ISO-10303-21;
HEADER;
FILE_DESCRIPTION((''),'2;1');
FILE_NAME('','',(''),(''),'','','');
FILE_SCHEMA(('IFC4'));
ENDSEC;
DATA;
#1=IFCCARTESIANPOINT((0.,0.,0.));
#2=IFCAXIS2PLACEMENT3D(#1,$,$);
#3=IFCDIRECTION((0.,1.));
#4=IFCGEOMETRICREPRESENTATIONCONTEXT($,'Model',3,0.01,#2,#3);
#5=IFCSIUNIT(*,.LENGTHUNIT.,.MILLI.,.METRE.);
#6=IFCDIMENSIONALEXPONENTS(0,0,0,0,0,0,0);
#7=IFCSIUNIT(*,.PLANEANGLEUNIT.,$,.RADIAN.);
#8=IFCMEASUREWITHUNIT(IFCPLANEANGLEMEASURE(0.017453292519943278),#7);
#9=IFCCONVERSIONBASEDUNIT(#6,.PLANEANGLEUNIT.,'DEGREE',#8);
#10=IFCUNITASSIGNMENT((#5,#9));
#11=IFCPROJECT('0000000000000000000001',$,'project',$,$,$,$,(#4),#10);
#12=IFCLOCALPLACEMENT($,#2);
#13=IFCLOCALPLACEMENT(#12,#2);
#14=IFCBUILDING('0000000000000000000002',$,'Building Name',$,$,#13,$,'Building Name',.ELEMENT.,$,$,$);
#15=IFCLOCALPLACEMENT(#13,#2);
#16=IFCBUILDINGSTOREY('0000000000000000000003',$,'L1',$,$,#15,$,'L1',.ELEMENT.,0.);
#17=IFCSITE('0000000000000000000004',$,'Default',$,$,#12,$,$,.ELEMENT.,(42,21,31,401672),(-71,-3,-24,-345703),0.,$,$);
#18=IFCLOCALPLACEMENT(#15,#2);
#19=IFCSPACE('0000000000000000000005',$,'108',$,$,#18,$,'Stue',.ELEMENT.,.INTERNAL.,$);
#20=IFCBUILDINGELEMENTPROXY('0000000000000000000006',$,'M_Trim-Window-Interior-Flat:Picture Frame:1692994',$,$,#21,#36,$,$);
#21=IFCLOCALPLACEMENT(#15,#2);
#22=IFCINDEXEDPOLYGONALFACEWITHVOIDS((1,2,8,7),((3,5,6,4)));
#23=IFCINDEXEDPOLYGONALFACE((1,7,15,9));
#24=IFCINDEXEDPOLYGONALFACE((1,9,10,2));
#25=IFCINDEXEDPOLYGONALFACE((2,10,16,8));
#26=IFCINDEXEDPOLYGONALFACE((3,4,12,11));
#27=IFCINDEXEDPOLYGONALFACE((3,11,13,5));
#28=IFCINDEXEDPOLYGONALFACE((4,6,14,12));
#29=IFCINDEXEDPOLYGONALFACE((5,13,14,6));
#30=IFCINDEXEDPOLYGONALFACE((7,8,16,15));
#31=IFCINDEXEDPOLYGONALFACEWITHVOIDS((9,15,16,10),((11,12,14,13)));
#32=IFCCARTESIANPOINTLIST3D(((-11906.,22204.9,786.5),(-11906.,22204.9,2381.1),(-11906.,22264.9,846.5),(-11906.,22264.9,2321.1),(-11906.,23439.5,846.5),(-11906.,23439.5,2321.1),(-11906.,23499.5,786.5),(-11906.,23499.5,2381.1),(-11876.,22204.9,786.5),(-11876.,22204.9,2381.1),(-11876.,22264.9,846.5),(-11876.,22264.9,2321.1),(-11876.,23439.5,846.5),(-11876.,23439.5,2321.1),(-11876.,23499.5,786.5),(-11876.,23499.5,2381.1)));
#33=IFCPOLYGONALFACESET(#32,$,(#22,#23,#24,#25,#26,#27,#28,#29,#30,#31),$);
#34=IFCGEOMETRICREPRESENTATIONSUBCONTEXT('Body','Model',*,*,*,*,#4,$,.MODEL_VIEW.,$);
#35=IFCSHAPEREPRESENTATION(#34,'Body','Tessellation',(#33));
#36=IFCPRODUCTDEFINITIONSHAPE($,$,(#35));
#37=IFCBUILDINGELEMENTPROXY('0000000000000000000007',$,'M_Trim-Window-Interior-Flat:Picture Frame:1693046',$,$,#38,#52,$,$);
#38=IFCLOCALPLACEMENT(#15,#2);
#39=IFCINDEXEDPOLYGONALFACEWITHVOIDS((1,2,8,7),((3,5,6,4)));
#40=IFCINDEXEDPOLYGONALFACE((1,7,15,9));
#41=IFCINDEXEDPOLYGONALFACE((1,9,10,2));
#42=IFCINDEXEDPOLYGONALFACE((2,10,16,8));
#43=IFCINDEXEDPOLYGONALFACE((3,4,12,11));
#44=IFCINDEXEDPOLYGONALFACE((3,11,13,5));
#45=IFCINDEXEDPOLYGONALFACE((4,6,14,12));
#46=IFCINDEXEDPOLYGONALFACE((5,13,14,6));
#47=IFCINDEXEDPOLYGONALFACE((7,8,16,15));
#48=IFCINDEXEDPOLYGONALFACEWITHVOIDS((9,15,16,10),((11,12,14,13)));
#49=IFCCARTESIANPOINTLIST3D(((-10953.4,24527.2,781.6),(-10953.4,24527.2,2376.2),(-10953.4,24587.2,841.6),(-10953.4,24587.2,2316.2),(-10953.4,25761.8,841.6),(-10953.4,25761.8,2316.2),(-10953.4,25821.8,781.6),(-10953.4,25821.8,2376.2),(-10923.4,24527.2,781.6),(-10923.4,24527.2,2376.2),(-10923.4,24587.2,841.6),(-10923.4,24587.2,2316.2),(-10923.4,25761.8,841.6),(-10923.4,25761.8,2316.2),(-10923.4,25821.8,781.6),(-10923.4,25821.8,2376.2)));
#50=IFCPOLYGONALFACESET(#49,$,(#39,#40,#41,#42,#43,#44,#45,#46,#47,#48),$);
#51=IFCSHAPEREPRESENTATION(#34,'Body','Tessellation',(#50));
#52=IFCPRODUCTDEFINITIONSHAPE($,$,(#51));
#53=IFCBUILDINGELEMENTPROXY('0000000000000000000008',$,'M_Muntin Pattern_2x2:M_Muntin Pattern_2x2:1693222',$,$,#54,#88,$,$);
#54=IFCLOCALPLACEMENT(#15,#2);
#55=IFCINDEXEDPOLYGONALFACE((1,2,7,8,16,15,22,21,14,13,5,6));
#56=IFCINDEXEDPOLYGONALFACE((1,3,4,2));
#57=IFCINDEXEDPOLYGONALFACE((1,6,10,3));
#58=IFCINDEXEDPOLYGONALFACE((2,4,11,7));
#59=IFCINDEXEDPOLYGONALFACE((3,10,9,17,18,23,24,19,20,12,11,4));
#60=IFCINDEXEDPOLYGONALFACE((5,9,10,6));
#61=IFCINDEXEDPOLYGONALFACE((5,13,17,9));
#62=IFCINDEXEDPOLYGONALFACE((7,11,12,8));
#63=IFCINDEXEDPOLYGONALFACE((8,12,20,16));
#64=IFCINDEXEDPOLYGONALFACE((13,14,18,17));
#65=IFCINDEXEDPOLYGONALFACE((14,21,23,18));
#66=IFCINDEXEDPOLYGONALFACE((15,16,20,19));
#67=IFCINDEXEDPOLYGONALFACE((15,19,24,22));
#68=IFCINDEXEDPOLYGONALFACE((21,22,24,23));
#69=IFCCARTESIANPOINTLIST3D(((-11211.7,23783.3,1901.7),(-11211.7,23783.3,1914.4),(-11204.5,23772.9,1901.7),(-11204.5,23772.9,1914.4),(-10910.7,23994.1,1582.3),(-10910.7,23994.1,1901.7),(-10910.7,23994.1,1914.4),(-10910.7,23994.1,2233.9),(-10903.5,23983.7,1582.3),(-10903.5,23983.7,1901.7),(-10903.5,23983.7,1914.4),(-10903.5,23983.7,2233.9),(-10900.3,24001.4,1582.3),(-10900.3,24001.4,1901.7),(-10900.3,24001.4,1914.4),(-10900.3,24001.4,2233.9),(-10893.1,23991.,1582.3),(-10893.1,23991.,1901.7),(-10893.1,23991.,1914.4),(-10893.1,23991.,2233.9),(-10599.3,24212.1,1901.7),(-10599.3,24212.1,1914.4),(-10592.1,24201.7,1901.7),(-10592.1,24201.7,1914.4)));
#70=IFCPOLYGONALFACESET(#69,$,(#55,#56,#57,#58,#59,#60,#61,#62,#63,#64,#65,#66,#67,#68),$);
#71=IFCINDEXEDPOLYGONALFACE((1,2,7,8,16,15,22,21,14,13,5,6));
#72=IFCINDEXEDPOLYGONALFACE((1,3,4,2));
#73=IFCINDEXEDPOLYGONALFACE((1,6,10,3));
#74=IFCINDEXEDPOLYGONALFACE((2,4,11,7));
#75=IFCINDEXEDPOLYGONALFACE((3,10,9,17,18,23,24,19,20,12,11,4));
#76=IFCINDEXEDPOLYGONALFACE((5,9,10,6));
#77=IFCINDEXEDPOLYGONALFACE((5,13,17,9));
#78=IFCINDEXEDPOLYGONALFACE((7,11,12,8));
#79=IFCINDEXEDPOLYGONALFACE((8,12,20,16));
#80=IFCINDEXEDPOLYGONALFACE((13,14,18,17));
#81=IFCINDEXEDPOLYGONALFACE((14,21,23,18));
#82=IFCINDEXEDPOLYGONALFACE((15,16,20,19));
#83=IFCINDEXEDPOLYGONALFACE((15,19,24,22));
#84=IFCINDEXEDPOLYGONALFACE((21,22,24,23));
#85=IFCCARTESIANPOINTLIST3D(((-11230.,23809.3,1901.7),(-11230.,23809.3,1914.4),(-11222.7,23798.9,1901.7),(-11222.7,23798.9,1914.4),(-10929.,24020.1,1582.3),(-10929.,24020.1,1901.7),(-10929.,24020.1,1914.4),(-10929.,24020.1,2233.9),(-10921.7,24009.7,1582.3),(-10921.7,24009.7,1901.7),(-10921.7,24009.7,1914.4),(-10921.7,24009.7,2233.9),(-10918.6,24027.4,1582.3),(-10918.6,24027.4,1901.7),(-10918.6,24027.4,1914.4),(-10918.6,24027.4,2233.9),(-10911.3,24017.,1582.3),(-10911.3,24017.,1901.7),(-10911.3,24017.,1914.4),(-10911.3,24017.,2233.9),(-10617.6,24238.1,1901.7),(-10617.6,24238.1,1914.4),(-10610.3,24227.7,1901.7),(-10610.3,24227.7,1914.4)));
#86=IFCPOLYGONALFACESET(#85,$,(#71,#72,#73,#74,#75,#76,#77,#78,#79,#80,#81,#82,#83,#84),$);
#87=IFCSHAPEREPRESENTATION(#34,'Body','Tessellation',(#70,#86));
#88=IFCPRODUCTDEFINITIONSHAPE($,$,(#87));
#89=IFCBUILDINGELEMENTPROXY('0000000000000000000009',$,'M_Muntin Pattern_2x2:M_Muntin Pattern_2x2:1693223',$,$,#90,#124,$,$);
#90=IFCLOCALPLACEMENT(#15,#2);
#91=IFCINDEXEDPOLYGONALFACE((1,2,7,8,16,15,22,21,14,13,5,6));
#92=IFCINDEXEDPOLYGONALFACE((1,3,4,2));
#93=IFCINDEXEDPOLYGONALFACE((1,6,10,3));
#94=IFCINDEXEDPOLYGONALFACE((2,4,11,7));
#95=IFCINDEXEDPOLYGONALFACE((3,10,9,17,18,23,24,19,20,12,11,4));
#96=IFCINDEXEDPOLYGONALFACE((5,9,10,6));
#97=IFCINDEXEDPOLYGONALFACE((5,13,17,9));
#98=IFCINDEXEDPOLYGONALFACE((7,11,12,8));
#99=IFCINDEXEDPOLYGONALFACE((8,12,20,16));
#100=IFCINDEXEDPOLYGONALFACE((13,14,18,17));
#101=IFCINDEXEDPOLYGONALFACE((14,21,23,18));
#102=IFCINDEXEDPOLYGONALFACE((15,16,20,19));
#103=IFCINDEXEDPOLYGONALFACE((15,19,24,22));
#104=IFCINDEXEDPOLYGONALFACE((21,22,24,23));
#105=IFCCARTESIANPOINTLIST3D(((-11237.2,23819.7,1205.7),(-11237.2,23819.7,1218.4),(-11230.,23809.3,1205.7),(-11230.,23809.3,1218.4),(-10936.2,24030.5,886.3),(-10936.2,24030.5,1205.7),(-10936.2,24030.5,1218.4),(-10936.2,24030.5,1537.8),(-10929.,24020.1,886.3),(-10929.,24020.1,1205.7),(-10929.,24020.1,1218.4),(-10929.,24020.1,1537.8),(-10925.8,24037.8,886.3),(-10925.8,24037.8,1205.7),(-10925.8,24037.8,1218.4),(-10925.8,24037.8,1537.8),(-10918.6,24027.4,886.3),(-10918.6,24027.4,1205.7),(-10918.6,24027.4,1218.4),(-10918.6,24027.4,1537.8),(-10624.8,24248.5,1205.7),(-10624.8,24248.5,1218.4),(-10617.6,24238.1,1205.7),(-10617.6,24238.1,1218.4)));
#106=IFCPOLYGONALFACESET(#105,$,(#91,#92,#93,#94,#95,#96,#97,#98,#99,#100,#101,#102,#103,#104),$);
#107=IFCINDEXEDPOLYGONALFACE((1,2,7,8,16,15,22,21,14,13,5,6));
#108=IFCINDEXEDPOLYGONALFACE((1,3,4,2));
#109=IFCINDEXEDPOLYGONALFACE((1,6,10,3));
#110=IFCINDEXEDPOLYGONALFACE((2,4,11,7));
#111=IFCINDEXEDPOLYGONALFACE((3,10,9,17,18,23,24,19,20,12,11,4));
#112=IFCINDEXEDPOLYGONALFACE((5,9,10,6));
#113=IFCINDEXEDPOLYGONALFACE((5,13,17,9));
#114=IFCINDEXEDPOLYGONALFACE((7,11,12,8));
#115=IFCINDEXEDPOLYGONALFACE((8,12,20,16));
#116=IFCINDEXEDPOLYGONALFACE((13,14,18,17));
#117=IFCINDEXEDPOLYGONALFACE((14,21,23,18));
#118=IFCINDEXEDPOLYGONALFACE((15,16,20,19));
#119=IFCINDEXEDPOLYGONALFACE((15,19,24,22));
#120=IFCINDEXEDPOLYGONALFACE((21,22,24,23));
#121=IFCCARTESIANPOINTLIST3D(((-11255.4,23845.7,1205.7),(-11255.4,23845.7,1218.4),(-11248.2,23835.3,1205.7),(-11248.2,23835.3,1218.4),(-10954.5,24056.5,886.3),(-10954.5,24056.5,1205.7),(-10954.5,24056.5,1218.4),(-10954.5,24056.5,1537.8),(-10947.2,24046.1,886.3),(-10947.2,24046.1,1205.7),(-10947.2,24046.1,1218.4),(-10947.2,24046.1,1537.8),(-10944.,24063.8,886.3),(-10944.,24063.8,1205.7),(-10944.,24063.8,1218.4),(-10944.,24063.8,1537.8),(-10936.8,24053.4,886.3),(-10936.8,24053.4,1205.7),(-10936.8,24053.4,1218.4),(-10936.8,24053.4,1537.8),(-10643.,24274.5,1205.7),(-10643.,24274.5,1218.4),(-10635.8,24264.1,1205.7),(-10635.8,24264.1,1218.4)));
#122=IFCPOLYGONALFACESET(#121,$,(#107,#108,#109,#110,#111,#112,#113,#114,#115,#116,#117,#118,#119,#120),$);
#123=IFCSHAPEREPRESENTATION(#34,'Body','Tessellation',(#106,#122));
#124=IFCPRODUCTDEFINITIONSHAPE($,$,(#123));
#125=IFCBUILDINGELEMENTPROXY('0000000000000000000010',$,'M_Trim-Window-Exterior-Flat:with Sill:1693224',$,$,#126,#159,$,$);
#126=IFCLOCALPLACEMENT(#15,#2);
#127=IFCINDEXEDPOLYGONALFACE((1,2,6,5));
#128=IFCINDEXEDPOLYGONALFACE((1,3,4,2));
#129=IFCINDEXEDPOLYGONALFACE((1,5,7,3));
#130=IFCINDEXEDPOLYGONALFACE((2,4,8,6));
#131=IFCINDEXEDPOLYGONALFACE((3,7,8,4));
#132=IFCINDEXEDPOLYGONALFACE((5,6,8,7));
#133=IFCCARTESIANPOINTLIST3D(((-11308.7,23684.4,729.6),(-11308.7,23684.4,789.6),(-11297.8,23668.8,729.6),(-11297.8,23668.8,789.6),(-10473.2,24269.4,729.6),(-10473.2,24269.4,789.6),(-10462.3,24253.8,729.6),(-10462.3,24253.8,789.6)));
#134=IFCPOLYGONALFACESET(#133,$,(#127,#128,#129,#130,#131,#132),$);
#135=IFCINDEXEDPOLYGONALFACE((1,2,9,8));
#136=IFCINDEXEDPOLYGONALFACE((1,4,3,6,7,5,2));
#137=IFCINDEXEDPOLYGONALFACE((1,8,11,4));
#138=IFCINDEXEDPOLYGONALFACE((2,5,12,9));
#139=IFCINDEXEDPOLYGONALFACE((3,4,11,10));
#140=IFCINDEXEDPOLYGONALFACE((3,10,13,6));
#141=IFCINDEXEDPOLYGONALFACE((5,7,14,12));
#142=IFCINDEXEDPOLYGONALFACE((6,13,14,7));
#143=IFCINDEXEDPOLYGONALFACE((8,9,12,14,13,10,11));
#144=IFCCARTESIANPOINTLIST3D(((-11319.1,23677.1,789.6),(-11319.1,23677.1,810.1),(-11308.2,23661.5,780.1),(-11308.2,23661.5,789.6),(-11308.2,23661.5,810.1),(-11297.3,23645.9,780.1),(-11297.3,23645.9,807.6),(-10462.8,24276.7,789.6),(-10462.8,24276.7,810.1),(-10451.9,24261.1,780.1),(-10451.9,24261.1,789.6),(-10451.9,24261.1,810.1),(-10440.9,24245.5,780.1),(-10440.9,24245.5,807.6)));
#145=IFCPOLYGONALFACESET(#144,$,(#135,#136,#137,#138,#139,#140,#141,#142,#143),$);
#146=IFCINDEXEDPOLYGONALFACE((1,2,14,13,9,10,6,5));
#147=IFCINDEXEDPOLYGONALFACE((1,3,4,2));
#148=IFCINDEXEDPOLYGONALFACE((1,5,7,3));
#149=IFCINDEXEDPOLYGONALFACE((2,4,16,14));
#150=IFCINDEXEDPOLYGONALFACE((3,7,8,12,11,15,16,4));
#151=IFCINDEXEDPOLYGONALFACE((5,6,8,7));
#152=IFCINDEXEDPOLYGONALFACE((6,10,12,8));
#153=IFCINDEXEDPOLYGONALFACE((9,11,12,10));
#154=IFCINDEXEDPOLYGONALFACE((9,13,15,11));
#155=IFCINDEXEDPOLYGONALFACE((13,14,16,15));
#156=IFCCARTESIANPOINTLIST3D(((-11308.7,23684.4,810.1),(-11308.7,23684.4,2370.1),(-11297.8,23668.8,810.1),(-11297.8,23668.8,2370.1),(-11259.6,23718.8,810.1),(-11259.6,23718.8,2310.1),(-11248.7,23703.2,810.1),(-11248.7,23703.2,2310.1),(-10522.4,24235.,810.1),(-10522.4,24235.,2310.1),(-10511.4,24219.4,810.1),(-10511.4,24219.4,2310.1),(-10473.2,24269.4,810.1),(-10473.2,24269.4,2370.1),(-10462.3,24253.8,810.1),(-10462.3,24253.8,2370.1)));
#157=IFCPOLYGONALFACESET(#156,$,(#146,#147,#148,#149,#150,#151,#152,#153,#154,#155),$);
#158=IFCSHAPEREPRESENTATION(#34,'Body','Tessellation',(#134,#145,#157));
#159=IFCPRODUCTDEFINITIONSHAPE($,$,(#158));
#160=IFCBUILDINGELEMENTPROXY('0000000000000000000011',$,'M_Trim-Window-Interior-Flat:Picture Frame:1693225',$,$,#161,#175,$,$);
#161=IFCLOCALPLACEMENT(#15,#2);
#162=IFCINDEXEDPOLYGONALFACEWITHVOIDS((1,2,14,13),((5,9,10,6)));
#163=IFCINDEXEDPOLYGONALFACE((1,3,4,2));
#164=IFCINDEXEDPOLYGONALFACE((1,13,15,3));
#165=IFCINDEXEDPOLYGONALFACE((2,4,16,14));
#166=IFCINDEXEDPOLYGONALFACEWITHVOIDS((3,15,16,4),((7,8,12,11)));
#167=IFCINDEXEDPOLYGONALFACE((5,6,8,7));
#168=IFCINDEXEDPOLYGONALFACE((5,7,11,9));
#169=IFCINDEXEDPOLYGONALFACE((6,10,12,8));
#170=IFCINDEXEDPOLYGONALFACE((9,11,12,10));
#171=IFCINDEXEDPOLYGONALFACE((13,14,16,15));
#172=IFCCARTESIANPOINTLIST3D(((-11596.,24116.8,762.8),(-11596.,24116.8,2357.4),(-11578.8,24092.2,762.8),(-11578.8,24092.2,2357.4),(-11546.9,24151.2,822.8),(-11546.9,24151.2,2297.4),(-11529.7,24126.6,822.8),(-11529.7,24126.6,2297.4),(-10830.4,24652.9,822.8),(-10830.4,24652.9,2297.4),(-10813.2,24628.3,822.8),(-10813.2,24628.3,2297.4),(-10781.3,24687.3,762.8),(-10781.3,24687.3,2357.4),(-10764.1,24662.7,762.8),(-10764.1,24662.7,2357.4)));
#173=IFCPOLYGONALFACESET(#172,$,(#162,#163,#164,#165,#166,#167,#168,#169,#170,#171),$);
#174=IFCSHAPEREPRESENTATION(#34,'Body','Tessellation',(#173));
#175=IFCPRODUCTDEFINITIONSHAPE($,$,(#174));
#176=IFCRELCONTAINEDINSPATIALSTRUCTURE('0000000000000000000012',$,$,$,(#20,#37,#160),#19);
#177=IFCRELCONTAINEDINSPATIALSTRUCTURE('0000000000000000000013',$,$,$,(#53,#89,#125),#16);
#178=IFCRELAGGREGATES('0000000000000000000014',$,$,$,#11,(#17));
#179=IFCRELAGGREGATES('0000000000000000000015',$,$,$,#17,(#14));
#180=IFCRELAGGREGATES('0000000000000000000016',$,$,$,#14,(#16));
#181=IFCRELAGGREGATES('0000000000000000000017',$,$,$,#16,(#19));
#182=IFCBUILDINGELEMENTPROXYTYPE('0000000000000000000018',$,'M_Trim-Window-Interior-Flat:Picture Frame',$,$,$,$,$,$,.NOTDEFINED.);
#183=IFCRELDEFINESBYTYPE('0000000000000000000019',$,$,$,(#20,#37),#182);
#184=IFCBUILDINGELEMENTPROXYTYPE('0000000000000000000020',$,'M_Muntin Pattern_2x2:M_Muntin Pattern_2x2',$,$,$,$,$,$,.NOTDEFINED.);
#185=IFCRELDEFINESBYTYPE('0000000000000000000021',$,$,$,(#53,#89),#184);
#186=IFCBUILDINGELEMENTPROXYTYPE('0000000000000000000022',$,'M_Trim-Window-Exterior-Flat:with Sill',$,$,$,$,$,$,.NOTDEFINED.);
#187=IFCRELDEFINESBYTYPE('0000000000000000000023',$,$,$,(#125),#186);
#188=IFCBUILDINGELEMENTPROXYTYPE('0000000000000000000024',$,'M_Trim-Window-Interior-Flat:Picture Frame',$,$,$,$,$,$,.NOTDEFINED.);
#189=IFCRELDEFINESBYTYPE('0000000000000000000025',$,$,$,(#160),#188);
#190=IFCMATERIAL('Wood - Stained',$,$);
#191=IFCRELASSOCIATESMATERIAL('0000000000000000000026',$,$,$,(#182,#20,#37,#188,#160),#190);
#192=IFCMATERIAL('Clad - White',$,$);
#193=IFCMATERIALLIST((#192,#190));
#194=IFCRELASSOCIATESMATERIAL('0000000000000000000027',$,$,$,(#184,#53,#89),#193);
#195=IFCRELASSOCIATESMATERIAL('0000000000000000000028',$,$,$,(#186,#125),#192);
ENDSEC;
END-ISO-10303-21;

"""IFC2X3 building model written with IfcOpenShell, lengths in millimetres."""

from ifc_helpers import new_model, entity, si_unit, converted_unit, direction, frame, frame_2d, origin, place, context, subcontext, project, spatial, polyline, rectangle, outline, extrude, source, transform, mapped, material, material_list, type_object, type_shapes, element, save


model = new_model("IFC2X3")

# Units and contexts
model_context = context("Model", 3, precision=0.01, world=origin(), true_north=direction((0.0, 1.0)))
body_context = subcontext(model_context, "Body", "Model", "MODEL_VIEW")
ifc_project = project(units=[si_unit("LENGTHUNIT", "METRE", prefix="MILLI"), converted_unit("PLANEANGLEUNIT", "DEGREE", entity("IfcPlaneAngleMeasure", 0.017453292519943278), si_unit("PLANEANGLEUNIT", "RADIAN"), dimensions=[0, 0, 0, 0, 0, 0, 0])], contexts=[model_context])

# Site, building, storey
site_placement = place(None, origin())
site = spatial("IfcSite", under=ifc_project, at=site_placement, Name="Default", CompositionType="ELEMENT", RefLatitude=(42, 21, 31, 401672), RefLongitude=(-71, -3, -24, -345703), RefElevation=0.0)
building_placement = place(site_placement, origin())
building = spatial("IfcBuilding", under=site, at=building_placement, Name="Building Name", LongName="Building Name", CompositionType="ELEMENT")
storey_placement = place(building_placement, origin())
storey = spatial("IfcBuildingStorey", under=building, at=storey_placement, Name="L1", LongName="L1", CompositionType="ELEMENT", Elevation=0.0)

# Shared definitions
ifc_material_1 = material(Name="Wood - Stained")

# Shared definitions
ifc_material_2 = material(Name="Clad - White")
ifc_material_list_1 = material_list([ifc_material_2, ifc_material_1])

# Shared definitions
space_placement = place(storey_placement, origin())
space = spatial("IfcSpace", under=storey, at=space_placement, Name="108", LongName="Stue", CompositionType="ELEMENT", InteriorOrExteriorSpace="INTERNAL")

# Building element proxies
building_element_proxy_type_1 = type_object("IfcBuildingElementProxyType", Name="M_Trim-Window-Interior-Flat:Picture Frame", PredefinedType="NOTDEFINED", material=ifc_material_1)
shared_shape_1 = source(origin(), body_context, "Body", "SweptSolid", [
    extrude(outline(polyline([(-647.3, -797.3), (647.3, -797.3), (647.3, 797.3), (-647.3, 797.3), (-647.3, -797.3)]), holes=[polyline([(-587.3, -737.3), (-587.3, 737.3), (587.3, 737.3), (587.3, -737.3), (-587.3, -737.3)])]), frame((0.0, -750.0, 0.0), z_axis=(0.0, 0.0, 1.0), x_axis=(-1.0, 0.0, 0.0)), (0.0, 0.0, 1.0), 30.0),
])
type_shapes(building_element_proxy_type_1, [shared_shape_1])
for number, where, z_axis, x_axis, name in (
    (1, (-11876.0, 22852.2, 2333.8), (-1.0, 0.0, 0.0), (0.0, -1.0, 0.0), "M_Trim-Window-Interior-Flat:Picture Frame:1692994"),
    (2, (-10923.4, 25174.5, 2328.9), (-1.0, 0.0, 0.0), (0.0, -1.0, 0.0), "M_Trim-Window-Interior-Flat:Picture Frame:1693046"),
):
    element("IfcBuildingElementProxy", number, at=place(space_placement, frame(where, z_axis=z_axis, x_axis=x_axis)), inside=space, type_object=building_element_proxy_type_1, material=ifc_material_1, Name=name, context=body_context, shape_type="MappedRepresentation", body=[
        mapped(shared_shape_1, transform((0.0, 0.0, 0.0), scale=1.0)),
    ])
building_element_proxy_type_2 = type_object("IfcBuildingElementProxyType", Name="M_Muntin Pattern_2x2:M_Muntin Pattern_2x2", PredefinedType="NOTDEFINED", material=ifc_material_list_1)
shared_shape_2 = source(origin(), body_context, "Body", "SweptSolid", [
    extrude(outline(polyline([(6.4, -6.4), (325.8, -6.4), (325.8, 6.3), (6.4, 6.3), (6.4, 373.8), (-6.3, 373.8), (-6.3, 6.3), (-325.8, 6.3), (-325.8, -6.4), (-6.3, -6.4), (-6.3, -373.8), (6.4, -373.8), (6.4, -6.4)])), frame((0.0, 9.5, 325.8), z_axis=(0.0, 1.0, 0.0), x_axis=(0.0, 0.0, 1.0)), (0.0, 0.0, 1.0), 12.7),
    extrude(outline(polyline([(6.4, -6.4), (325.8, -6.4), (325.8, 6.3), (6.4, 6.3), (6.4, 373.8), (-6.3, 373.8), (-6.3, 6.3), (-325.8, 6.3), (-325.8, -6.4), (-6.3, -6.4), (-6.3, -373.8), (6.4, -373.8), (6.4, -6.4)])), frame((0.0, -22.2, 325.8), z_axis=(0.0, 1.0, 0.0), x_axis=(0.0, 0.0, 1.0)), (0.0, 0.0, 1.0), 12.7),
])
type_shapes(building_element_proxy_type_2, [shared_shape_2])
for number, where, z_axis, x_axis, name in (
    (3, (-10911.0, 24005.5, 1582.3), (0.0, 0.0, 1.0), (-0.819152, -0.573576, 0.0), "M_Muntin Pattern_2x2:M_Muntin Pattern_2x2:1693222"),
    (4, (-10936.5, 24041.9, 886.3), (0.0, 0.0, 1.0), (-0.819152, -0.573576, 0.0), "M_Muntin Pattern_2x2:M_Muntin Pattern_2x2:1693223"),
):
    element("IfcBuildingElementProxy", number, at=place(storey_placement, frame(where, z_axis=z_axis, x_axis=x_axis)), inside=storey, type_object=building_element_proxy_type_2, material=ifc_material_list_1, Name=name, context=body_context, shape_type="MappedRepresentation", body=[
        mapped(shared_shape_2, transform((0.0, 0.0, 0.0), scale=1.0)),
    ])
building_element_proxy_type_3 = type_object("IfcBuildingElementProxyType", Name="M_Trim-Window-Exterior-Flat:with Sill", PredefinedType="NOTDEFINED", material=ifc_material_2)
shared_shape_3 = source(origin(), body_context, "Body", "SweptSolid", [
    extrude(rectangle(XDim=1020.0, YDim=60.0, at=frame_2d((0.0, 0.0), x_axis=(1.0, 0.0))), frame((0.0, -1550.4, 0.0), z_axis=(0.0, 0.0, 1.0), x_axis=(-1.0, 0.0, 0.0)), (0.0, 0.0, 1.0), 19.0),
    extrude(outline(polyline([(-19.0, -15.2), (0.0, -15.2), (0.0, -5.7), (19.0, -5.7), (19.0, 14.8), (0.0, 14.8), (-19.0, 12.3), (-19.0, -15.2)])), frame((-522.7, -1514.8, 19.0), z_axis=(1.0, 0.0, 0.0), x_axis=(0.0, 0.0, -1.0)), (0.0, 0.0, 1.0), 1045.4),
    extrude(outline(polyline([(-795.0, -510.0), (765.0, -510.0), (765.0, -450.0), (-735.0, -450.0), (-735.0, 450.0), (765.0, 450.0), (765.0, 510.0), (-795.0, 510.0), (-795.0, -510.0)])), frame((0.0, -735.0, 0.0), z_axis=(0.0, 0.0, 1.0), x_axis=(0.0, -1.0, 0.0)), (0.0, 0.0, 1.0), 19.0),
])
type_shapes(building_element_proxy_type_3, [shared_shape_3])
proxy_1_placement = place(storey_placement, frame((-10891.0, 23976.9, 2310.1), z_axis=(0.573576, -0.819152, 0.0), x_axis=(0.819152, 0.573576, 0.0)))
element("IfcBuildingElementProxy", 5, at=proxy_1_placement, inside=storey, type_object=building_element_proxy_type_3, material=ifc_material_2, Name="M_Trim-Window-Exterior-Flat:with Sill:1693224", context=body_context, shape_type="MappedRepresentation", body=[
    mapped(shared_shape_3, transform((0.0, 0.0, 0.0), scale=1.0)),
])
building_element_proxy_type_4 = type_object("IfcBuildingElementProxyType", Name="M_Trim-Window-Interior-Flat:Picture Frame", PredefinedType="NOTDEFINED", material=ifc_material_1)
shared_shape_4 = source(origin(), body_context, "Body", "SweptSolid", [
    extrude(outline(polyline([(-497.3, -797.3), (497.3, -797.3), (497.3, 797.3), (-497.3, 797.3), (-497.3, -797.3)]), holes=[polyline([(-437.3, -737.3), (-437.3, 737.3), (437.3, 737.3), (437.3, -737.3), (-437.3, -737.3)])]), frame((0.0, -750.0, 0.0), z_axis=(0.0, 0.0, 1.0), x_axis=(-1.0, 0.0, 0.0)), (0.0, 0.0, 1.0), 30.0),
])
type_shapes(building_element_proxy_type_4, [shared_shape_4])
proxy_2_placement = place(space_placement, frame((-11171.5, 24377.5, 2310.1), z_axis=(-0.573576, 0.819152, 0.0), x_axis=(-0.819152, -0.573576, 0.0)))
element("IfcBuildingElementProxy", 6, at=proxy_2_placement, inside=space, type_object=building_element_proxy_type_4, material=ifc_material_1, Name="M_Trim-Window-Interior-Flat:Picture Frame:1693225", context=body_context, shape_type="MappedRepresentation", body=[
    mapped(shared_shape_4, transform((0.0, 0.0, 0.0), scale=1.0)),
])

save(model, "model.ifc")
